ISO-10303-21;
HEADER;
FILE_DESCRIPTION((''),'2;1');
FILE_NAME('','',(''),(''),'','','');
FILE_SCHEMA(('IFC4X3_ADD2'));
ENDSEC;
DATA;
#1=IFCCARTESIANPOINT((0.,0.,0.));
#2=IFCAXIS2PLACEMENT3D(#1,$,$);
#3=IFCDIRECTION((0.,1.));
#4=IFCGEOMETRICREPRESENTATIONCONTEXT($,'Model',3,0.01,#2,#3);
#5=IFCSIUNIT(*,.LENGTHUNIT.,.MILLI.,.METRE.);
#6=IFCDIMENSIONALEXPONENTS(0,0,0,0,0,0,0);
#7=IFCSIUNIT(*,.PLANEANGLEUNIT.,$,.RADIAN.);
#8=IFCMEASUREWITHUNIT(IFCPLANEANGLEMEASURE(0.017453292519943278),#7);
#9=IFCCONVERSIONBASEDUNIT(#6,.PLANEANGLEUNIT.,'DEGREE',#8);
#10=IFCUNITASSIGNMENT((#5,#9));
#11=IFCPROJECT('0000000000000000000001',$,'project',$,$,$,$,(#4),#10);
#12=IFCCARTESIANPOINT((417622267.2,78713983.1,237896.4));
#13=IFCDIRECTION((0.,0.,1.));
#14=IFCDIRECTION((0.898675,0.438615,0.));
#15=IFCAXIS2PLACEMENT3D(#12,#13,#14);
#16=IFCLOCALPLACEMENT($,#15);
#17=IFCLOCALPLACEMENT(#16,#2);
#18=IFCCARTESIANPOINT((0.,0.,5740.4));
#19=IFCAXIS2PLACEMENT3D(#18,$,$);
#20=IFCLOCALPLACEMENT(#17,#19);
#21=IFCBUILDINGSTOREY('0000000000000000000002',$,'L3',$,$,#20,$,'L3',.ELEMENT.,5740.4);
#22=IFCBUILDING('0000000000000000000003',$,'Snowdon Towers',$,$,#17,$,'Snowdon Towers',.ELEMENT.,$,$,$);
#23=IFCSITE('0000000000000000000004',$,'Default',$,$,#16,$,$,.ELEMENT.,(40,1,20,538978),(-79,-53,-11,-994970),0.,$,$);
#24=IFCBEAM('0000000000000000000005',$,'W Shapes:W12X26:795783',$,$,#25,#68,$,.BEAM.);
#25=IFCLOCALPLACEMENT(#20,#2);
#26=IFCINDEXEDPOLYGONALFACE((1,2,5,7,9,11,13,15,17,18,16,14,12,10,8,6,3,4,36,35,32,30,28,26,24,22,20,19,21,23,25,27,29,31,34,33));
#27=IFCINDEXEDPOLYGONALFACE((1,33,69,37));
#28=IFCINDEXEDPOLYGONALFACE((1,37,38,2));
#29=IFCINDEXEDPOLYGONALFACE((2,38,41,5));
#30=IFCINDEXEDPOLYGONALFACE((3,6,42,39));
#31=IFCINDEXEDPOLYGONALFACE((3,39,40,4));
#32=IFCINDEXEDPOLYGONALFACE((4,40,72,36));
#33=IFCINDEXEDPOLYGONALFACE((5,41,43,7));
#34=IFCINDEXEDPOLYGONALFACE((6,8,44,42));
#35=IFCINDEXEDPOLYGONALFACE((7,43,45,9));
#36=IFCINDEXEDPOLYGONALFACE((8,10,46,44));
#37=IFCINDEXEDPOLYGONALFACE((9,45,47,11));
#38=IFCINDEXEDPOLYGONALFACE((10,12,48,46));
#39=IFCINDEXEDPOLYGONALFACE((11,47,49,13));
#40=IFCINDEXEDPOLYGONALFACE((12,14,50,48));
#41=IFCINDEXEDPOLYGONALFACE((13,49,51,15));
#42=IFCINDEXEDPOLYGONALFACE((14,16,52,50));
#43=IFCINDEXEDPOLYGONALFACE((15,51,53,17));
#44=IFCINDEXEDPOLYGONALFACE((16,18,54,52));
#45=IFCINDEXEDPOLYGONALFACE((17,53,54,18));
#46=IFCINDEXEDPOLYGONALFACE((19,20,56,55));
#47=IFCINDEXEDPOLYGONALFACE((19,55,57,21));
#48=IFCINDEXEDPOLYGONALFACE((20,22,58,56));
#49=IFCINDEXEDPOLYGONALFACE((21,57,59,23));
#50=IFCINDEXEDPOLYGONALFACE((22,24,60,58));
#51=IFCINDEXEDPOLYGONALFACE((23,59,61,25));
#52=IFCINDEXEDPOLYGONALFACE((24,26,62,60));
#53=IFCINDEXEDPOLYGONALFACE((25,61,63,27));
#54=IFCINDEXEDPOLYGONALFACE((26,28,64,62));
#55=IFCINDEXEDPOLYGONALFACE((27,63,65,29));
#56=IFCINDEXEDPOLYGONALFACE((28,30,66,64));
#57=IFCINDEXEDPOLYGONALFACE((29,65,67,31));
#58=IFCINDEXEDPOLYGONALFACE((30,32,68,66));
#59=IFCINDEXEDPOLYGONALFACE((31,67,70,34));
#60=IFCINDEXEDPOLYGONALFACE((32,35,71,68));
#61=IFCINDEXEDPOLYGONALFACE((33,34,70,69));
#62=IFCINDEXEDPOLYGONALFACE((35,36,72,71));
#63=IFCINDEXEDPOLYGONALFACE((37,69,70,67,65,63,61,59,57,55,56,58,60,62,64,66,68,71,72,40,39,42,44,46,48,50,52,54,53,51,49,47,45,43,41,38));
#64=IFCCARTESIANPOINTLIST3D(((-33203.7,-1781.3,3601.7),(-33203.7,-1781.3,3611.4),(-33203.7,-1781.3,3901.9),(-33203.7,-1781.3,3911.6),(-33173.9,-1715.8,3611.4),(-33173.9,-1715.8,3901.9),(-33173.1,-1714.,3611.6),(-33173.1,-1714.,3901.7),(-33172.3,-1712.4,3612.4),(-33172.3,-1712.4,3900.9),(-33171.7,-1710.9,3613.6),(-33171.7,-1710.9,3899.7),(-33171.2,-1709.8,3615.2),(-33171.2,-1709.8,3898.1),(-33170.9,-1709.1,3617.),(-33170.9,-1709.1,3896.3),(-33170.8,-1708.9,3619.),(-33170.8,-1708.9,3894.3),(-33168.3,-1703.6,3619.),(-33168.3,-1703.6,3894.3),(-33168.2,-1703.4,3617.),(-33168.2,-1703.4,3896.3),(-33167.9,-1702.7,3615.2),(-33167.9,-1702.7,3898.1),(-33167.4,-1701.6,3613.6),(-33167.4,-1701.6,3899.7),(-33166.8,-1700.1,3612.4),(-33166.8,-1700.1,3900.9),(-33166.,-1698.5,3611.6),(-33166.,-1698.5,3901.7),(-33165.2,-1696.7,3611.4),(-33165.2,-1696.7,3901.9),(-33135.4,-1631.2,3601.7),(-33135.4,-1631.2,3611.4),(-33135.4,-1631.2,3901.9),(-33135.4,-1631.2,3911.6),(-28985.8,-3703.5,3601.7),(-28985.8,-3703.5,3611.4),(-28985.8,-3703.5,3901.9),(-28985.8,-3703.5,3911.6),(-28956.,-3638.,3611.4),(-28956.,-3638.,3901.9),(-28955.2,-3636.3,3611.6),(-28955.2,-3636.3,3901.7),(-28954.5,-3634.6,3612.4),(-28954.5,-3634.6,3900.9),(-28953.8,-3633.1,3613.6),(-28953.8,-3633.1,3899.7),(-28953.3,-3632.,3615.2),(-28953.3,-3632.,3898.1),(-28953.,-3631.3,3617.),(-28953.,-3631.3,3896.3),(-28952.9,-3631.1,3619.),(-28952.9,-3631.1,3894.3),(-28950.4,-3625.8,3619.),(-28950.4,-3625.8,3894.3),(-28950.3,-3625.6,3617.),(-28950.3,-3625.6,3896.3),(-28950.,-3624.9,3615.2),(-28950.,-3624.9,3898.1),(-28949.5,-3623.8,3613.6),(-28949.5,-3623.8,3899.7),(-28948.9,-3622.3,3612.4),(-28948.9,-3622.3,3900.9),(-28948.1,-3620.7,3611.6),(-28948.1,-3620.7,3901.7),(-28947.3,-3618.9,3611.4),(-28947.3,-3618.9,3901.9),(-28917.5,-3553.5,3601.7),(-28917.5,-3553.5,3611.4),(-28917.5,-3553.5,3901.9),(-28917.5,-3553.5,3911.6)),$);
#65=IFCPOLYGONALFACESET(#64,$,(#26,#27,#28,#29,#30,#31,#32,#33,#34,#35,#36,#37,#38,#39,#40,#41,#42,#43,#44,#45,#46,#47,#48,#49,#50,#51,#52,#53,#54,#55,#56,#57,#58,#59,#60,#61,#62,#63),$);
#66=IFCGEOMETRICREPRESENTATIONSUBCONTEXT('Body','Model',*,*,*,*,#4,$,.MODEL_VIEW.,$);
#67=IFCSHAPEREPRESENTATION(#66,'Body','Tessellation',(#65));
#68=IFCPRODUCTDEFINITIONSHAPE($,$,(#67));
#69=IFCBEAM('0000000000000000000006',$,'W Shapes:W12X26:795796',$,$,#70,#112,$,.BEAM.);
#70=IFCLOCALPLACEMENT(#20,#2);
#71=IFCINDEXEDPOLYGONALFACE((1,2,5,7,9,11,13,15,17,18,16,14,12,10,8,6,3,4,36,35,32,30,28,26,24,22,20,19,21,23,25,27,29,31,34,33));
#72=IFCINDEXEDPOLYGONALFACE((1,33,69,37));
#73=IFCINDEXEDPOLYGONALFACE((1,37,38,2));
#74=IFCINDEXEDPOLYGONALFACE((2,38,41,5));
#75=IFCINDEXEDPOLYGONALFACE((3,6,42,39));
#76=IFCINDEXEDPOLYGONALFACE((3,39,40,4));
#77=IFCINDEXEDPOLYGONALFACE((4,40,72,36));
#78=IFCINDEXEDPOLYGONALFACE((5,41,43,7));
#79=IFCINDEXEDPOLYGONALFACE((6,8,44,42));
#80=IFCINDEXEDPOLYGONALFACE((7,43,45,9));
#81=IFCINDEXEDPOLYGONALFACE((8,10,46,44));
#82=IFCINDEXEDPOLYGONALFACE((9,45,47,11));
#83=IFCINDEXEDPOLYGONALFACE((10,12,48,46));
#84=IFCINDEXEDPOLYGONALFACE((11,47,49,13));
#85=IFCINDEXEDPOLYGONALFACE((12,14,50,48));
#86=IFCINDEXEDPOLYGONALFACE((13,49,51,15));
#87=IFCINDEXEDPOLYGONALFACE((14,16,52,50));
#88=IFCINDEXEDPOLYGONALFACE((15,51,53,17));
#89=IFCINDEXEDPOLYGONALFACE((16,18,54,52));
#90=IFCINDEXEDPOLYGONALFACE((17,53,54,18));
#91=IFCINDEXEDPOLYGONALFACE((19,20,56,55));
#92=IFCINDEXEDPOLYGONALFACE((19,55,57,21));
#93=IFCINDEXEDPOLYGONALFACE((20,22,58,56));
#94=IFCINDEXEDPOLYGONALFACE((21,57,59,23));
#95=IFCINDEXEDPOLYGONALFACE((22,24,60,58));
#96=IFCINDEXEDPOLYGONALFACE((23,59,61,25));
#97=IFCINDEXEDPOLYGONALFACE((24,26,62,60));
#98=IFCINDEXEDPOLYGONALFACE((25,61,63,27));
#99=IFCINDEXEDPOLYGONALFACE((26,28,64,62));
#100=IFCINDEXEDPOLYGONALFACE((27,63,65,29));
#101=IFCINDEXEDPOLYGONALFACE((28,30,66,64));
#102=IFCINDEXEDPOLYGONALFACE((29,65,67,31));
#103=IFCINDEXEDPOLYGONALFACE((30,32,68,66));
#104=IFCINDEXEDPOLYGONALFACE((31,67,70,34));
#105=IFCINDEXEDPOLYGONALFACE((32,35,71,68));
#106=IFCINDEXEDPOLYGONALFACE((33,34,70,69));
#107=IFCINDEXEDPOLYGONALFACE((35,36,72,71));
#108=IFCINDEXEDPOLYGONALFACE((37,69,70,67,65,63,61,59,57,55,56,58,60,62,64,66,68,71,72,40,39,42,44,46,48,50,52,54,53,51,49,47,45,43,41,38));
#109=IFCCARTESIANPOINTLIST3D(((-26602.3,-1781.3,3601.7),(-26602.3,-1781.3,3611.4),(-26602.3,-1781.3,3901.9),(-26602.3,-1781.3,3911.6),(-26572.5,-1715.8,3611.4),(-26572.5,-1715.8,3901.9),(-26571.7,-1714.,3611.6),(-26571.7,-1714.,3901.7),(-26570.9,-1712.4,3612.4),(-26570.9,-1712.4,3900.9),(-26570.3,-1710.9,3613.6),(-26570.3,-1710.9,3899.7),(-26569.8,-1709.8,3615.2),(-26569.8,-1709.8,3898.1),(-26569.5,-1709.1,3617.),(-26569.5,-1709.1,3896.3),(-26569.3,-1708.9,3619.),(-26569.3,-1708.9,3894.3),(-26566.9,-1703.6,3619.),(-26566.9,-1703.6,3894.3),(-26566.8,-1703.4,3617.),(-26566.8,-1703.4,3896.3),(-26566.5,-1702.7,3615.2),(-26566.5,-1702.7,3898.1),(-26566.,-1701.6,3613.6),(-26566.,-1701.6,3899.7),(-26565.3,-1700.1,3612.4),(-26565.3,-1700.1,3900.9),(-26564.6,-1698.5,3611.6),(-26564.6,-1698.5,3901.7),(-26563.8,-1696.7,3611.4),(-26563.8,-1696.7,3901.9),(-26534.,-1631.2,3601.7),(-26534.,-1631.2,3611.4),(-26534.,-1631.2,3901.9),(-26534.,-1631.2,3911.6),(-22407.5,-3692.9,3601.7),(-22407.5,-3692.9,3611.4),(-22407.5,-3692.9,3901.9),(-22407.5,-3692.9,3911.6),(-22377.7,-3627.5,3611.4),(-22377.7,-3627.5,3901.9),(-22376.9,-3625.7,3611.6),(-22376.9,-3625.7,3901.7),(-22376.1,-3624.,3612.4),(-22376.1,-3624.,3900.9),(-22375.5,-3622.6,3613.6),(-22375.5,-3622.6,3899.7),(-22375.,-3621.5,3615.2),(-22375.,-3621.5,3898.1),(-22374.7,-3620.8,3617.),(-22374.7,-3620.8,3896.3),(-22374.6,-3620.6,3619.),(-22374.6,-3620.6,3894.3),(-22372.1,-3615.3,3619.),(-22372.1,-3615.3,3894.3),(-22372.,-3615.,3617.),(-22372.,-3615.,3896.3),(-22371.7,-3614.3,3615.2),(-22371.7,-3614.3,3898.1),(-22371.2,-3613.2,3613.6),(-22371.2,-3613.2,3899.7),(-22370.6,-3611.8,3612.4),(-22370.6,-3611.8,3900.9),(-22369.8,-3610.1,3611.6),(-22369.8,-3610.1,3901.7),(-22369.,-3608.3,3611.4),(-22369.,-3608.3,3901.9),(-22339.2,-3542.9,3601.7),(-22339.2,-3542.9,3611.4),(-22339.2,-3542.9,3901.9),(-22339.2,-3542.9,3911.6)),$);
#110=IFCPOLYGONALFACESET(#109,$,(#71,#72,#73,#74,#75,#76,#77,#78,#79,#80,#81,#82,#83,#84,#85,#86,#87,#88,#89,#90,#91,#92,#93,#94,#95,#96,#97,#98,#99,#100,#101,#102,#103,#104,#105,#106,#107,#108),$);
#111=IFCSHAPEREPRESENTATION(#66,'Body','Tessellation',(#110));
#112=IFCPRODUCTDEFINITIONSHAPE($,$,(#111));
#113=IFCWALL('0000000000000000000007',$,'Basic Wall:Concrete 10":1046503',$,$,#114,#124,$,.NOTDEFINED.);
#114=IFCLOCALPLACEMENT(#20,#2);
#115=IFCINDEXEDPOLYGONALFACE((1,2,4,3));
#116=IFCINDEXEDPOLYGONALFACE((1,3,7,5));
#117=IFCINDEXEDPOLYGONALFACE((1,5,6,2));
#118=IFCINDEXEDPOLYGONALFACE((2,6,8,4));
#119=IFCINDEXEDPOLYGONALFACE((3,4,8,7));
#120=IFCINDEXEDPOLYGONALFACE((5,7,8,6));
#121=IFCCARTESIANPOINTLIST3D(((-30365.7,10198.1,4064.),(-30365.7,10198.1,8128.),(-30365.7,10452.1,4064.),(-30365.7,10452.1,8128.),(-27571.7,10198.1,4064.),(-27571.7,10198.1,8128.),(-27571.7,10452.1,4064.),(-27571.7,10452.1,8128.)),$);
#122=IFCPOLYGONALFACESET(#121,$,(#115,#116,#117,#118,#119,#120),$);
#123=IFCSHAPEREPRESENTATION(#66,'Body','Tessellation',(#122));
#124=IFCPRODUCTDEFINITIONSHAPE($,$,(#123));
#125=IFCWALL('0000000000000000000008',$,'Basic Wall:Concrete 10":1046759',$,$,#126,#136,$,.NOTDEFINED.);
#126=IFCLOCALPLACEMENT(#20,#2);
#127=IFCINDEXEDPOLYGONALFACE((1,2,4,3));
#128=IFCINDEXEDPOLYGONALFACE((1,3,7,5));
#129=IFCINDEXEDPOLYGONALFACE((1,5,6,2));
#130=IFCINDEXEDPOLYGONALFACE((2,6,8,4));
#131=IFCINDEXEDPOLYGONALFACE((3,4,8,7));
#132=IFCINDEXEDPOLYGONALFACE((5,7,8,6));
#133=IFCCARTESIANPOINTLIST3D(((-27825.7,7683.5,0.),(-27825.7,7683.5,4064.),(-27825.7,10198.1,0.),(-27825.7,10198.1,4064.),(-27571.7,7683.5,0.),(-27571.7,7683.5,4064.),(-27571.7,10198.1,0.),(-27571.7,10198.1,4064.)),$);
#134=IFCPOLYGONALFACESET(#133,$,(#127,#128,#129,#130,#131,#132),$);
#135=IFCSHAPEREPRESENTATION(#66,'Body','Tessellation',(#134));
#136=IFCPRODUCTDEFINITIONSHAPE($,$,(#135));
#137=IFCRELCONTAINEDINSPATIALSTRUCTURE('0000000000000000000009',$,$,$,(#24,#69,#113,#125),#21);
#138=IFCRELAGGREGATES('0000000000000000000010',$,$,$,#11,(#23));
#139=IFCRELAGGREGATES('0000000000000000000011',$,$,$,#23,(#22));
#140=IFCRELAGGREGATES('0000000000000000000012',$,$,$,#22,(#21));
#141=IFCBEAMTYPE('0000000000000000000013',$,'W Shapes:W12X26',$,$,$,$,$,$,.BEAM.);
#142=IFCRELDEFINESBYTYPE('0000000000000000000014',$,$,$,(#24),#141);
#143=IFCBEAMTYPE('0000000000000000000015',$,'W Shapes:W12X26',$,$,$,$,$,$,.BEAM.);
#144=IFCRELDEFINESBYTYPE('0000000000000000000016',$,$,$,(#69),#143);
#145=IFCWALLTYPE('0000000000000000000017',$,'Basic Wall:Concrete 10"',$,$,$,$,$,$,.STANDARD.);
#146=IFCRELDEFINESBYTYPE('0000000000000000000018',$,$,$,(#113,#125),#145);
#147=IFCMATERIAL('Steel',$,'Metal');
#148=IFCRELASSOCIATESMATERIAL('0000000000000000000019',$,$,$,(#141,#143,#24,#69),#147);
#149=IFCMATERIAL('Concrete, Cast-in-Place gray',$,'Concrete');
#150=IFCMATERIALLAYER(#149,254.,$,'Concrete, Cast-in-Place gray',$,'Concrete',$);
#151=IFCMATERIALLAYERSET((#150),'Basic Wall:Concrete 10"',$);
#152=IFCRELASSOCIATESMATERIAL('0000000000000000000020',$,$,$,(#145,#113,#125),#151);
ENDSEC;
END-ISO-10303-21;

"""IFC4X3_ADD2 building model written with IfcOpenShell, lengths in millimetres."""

from ifc_helpers import new_model, entity, si_unit, converted_unit, direction, frame, frame_2d, origin, place, context, subcontext, project, spatial, polyline, circle_curve, parameter, trimmed, segment, composite_curve, rectangle, outline, extrude, source, transform, mapped, material, layer, layer_set, material_profile, profile_set, profile_usage, type_object, type_shapes, element, save


model = new_model("IFC4X3_ADD2")

# Units and contexts
model_context = context("Model", 3, precision=0.01, world=origin(), true_north=direction((0.0, 1.0)))
body_context = subcontext(model_context, "Body", "Model", "MODEL_VIEW")
ifc_project = project(units=[si_unit("LENGTHUNIT", "METRE", prefix="MILLI"), converted_unit("PLANEANGLEUNIT", "DEGREE", entity("IfcPlaneAngleMeasure", 0.017453292519943278), si_unit("PLANEANGLEUNIT", "RADIAN"), dimensions=[0, 0, 0, 0, 0, 0, 0])], contexts=[model_context])

# Site, building, storey
site_placement = place(None, frame((417622267.2, 78713983.1, 237896.4), z_axis=(0.0, 0.0, 1.0), x_axis=(0.898675, 0.438615, 0.0)))
site = spatial("IfcSite", under=ifc_project, at=site_placement, Name="Default", CompositionType="ELEMENT", RefLatitude=(40, 1, 20, 538978), RefLongitude=(-79, -53, -11, -994970), RefElevation=0.0)
building_placement = place(site_placement, origin())
building = spatial("IfcBuilding", under=site, at=building_placement, Name="Snowdon Towers", LongName="Snowdon Towers", CompositionType="ELEMENT")
storey_placement = place(building_placement, frame((0.0, 0.0, 5740.4)))
storey = spatial("IfcBuildingStorey", under=building, at=storey_placement, Name="L3", LongName="L3", CompositionType="ELEMENT", Elevation=5740.4)

# Shared definitions
ifc_material_1 = material(Name="Steel", Category="Metal")

# Beams
ifc_material_profile_1 = material_profile(ifc_material_1, outline(composite_curve([segment(polyline([(-82.4, -145.3), (-82.4, -154.9)]), True, "CONTINUOUS"), segment(polyline([(-82.4, -154.9), (82.4, -154.9)]), True, "CONTINUOUS"), segment(polyline([(82.4, -154.9), (82.4, -145.3)]), True, "CONTINUOUS"), segment(polyline([(82.4, -145.3), (10.5, -145.3)]), True, "CONTINUOUS"), segment(trimmed(circle_curve(frame_2d((10.5, -137.7), x_axis=(1.0, 0.0)), 7.6), [parameter(180.0)], [parameter(270.0)], True, "PARAMETER"), False, "CONTINUOUS"), segment(polyline([(2.9, -137.7), (2.9, 137.7)]), True, "CONTINUOUS"), segment(trimmed(circle_curve(frame_2d((10.5, 137.7), x_axis=(1.0, 0.0)), 7.6), [parameter(90.0)], [parameter(180.0)], True, "PARAMETER"), False, "CONTINUOUS"), segment(polyline([(10.5, 145.3), (82.4, 145.3)]), True, "CONTINUOUS"), segment(polyline([(82.4, 145.3), (82.4, 154.9)]), True, "CONTINUOUS"), segment(polyline([(82.4, 154.9), (-82.4, 154.9)]), True, "CONTINUOUS"), segment(polyline([(-82.4, 154.9), (-82.4, 145.3)]), True, "CONTINUOUS"), segment(polyline([(-82.4, 145.3), (-10.5, 145.3)]), True, "CONTINUOUS"), segment(trimmed(circle_curve(frame_2d((-10.5, 137.7), x_axis=(1.0, 0.0)), 7.6), [parameter(360.0)], [parameter(90.0)], True, "PARAMETER"), False, "CONTINUOUS"), segment(polyline([(-2.9, 137.7), (-2.9, -137.7)]), True, "CONTINUOUS"), segment(trimmed(circle_curve(frame_2d((-10.5, -137.7), x_axis=(1.0, 0.0)), 7.6), [parameter(270.0)], [parameter(360.0)], True, "PARAMETER"), False, "CONTINUOUS"), segment(polyline([(-10.5, -145.3), (-82.4, -145.3)]), True, "CONTINUOUS")], self_intersect=False)), Name="W12X26")
ifc_profile_set_1 = profile_set([ifc_material_profile_1], Name="W12X26")
ifc_profile_usage_1 = profile_usage(ifc_profile_set_1, cardinal=8)
beam_type_1 = type_object("IfcBeamType", Name="W Shapes:W12X26", PredefinedType="BEAM", material=ifc_profile_set_1)
shared_shape_1 = source(origin(), body_context, "Body", "SweptSolid", [
    extrude(outline(composite_curve([segment(polyline([(-82.4, -145.3), (-82.4, -154.9)]), True, "CONTINUOUS"), segment(polyline([(-82.4, -154.9), (82.4, -154.9)]), True, "CONTINUOUS"), segment(polyline([(82.4, -154.9), (82.4, -145.3)]), True, "CONTINUOUS"), segment(polyline([(82.4, -145.3), (10.5, -145.3)]), True, "CONTINUOUS"), segment(trimmed(circle_curve(frame_2d((10.5, -137.7), x_axis=(0.0, -1.0)), 7.6), [parameter(270.0)], [parameter(360.0)], True, "PARAMETER"), False, "CONTINUOUS"), segment(polyline([(2.9, -137.7), (2.9, 137.7)]), True, "CONTINUOUS"), segment(trimmed(circle_curve(frame_2d((10.5, 137.7), x_axis=(-1.0, 0.0)), 7.6), [parameter(270.0)], [parameter(360.0)], True, "PARAMETER"), False, "CONTINUOUS"), segment(polyline([(10.5, 145.3), (82.4, 145.3)]), True, "CONTINUOUS"), segment(polyline([(82.4, 145.3), (82.4, 154.9)]), True, "CONTINUOUS"), segment(polyline([(82.4, 154.9), (-82.4, 154.9)]), True, "CONTINUOUS"), segment(polyline([(-82.4, 154.9), (-82.4, 145.3)]), True, "CONTINUOUS"), segment(polyline([(-82.4, 145.3), (-10.5, 145.3)]), True, "CONTINUOUS"), segment(trimmed(circle_curve(frame_2d((-10.5, 137.7), x_axis=(0.0, 1.0)), 7.6), [parameter(270.0)], [parameter(0.0)], True, "PARAMETER"), False, "CONTINUOUS"), segment(polyline([(-2.9, 137.7), (-2.9, -137.7)]), True, "CONTINUOUS"), segment(trimmed(circle_curve(frame_2d((-10.5, -137.7), x_axis=(1.0, 0.0)), 7.6), [parameter(270.0)], [parameter(0.0)], True, "PARAMETER"), False, "CONTINUOUS"), segment(polyline([(-10.5, -145.3), (-82.4, -145.3)]), True, "CONTINUOUS")], self_intersect=False)), frame((-2317.6, 0.0, 0.0), z_axis=(-1.0, 0.0, 0.0), x_axis=(0.0, -1.0, 0.0)), (0.0, 0.0, -1.0), 4635.2),
])
type_shapes(beam_type_1, [shared_shape_1])
beam_1_placement = place(storey_placement, frame((-31060.6, -2667.4, 3756.7), z_axis=(0.0, 0.0, 1.0), x_axis=(0.909961, -0.414693, 0.0)))
element("IfcBeam", 1, at=beam_1_placement, inside=storey, type_object=beam_type_1, material=ifc_profile_usage_1, Name="W Shapes:W12X26:795783", PredefinedType="BEAM", context=body_context, shape_type="MappedRepresentation", body=[
    mapped(shared_shape_1, transform((0.0, 0.0, 0.0), scale=1.0)),
])
beam_type_2 = type_object("IfcBeamType", Name="W Shapes:W12X26", PredefinedType="BEAM", material=ifc_profile_set_1)
shared_shape_2 = source(origin(), body_context, "Body", "SweptSolid", [
    extrude(outline(composite_curve([segment(polyline([(-82.4, -145.3), (-82.4, -154.9)]), True, "CONTINUOUS"), segment(polyline([(-82.4, -154.9), (82.4, -154.9)]), True, "CONTINUOUS"), segment(polyline([(82.4, -154.9), (82.4, -145.3)]), True, "CONTINUOUS"), segment(polyline([(82.4, -145.3), (10.5, -145.3)]), True, "CONTINUOUS"), segment(trimmed(circle_curve(frame_2d((10.5, -137.7), x_axis=(0.0, -1.0)), 7.6), [parameter(270.0)], [parameter(360.0)], True, "PARAMETER"), False, "CONTINUOUS"), segment(polyline([(2.9, -137.7), (2.9, 137.7)]), True, "CONTINUOUS"), segment(trimmed(circle_curve(frame_2d((10.5, 137.7), x_axis=(-1.0, 0.0)), 7.6), [parameter(270.0)], [parameter(360.0)], True, "PARAMETER"), False, "CONTINUOUS"), segment(polyline([(10.5, 145.3), (82.4, 145.3)]), True, "CONTINUOUS"), segment(polyline([(82.4, 145.3), (82.4, 154.9)]), True, "CONTINUOUS"), segment(polyline([(82.4, 154.9), (-82.4, 154.9)]), True, "CONTINUOUS"), segment(polyline([(-82.4, 154.9), (-82.4, 145.3)]), True, "CONTINUOUS"), segment(polyline([(-82.4, 145.3), (-10.5, 145.3)]), True, "CONTINUOUS"), segment(trimmed(circle_curve(frame_2d((-10.5, 137.7), x_axis=(0.0, 1.0)), 7.6), [parameter(270.0)], [parameter(0.0)], True, "PARAMETER"), False, "CONTINUOUS"), segment(polyline([(-2.9, 137.7), (-2.9, -137.7)]), True, "CONTINUOUS"), segment(trimmed(circle_curve(frame_2d((-10.5, -137.7), x_axis=(1.0, 0.0)), 7.6), [parameter(270.0)], [parameter(0.0)], True, "PARAMETER"), False, "CONTINUOUS"), segment(polyline([(-10.5, -145.3), (-82.4, -145.3)]), True, "CONTINUOUS")], self_intersect=False)), frame((-2304.9, 0.0, 0.0), z_axis=(-1.0, 0.0, 0.0), x_axis=(0.0, -1.0, 0.0)), (0.0, 0.0, -1.0), 4609.8),
])
type_shapes(beam_type_2, [shared_shape_2])
beam_2_placement = place(storey_placement, frame((-24470.7, -2662.1, 3756.7), z_axis=(0.0, 0.0, 1.0), x_axis=(0.909961, -0.414693, 0.0)))
element("IfcBeam", 2, at=beam_2_placement, inside=storey, type_object=beam_type_2, material=ifc_profile_usage_1, Name="W Shapes:W12X26:795796", PredefinedType="BEAM", context=body_context, shape_type="MappedRepresentation", body=[
    mapped(shared_shape_2, transform((0.0, 0.0, 0.0), scale=1.0)),
])

# Walls
ifc_material_2 = material(Name="Concrete, Cast-in-Place gray", Category="Concrete")
ifc_layer_1 = layer(ifc_material_2, 254.0, Name="Concrete, Cast-in-Place gray", Category="Concrete")
ifc_layer_set_1 = layer_set([ifc_layer_1], Name="Basic Wall:Concrete 10\"")
wall_type_1 = type_object("IfcWallType", Name="Basic Wall:Concrete 10\"", PredefinedType="STANDARD", material=ifc_layer_set_1)
wall_1_placement = place(storey_placement, frame((-30365.7, 10325.1, 4064.0)))
element("IfcWall", 3, at=wall_1_placement, inside=storey, type_object=wall_type_1, material=ifc_layer_set_1, Name="Basic Wall:Concrete 10\":1046503", PredefinedType="NOTDEFINED", context=body_context, shape_type="SweptSolid", body=[
    extrude(rectangle(XDim=2794.0, YDim=254.0, at=frame_2d((1397.0, 0.0), x_axis=(-1.0, 0.0))), origin(), (0.0, 0.0, 1.0), 4064.0),
])
wall_2_placement = place(storey_placement, frame((-27698.7, 10198.1, 0.0), z_axis=(0.0, 0.0, 1.0), x_axis=(0.0, -1.0, 0.0)))
element("IfcWall", 4, at=wall_2_placement, inside=storey, type_object=wall_type_1, material=ifc_layer_set_1, Name="Basic Wall:Concrete 10\":1046759", PredefinedType="NOTDEFINED", context=body_context, shape_type="SweptSolid", body=[
    extrude(rectangle(XDim=2514.6, YDim=254.0, at=frame_2d((1257.3, 0.0), x_axis=(-1.0, 0.0))), origin(), (0.0, 0.0, 1.0), 4064.0),
])

save(model, "model.ifc")
